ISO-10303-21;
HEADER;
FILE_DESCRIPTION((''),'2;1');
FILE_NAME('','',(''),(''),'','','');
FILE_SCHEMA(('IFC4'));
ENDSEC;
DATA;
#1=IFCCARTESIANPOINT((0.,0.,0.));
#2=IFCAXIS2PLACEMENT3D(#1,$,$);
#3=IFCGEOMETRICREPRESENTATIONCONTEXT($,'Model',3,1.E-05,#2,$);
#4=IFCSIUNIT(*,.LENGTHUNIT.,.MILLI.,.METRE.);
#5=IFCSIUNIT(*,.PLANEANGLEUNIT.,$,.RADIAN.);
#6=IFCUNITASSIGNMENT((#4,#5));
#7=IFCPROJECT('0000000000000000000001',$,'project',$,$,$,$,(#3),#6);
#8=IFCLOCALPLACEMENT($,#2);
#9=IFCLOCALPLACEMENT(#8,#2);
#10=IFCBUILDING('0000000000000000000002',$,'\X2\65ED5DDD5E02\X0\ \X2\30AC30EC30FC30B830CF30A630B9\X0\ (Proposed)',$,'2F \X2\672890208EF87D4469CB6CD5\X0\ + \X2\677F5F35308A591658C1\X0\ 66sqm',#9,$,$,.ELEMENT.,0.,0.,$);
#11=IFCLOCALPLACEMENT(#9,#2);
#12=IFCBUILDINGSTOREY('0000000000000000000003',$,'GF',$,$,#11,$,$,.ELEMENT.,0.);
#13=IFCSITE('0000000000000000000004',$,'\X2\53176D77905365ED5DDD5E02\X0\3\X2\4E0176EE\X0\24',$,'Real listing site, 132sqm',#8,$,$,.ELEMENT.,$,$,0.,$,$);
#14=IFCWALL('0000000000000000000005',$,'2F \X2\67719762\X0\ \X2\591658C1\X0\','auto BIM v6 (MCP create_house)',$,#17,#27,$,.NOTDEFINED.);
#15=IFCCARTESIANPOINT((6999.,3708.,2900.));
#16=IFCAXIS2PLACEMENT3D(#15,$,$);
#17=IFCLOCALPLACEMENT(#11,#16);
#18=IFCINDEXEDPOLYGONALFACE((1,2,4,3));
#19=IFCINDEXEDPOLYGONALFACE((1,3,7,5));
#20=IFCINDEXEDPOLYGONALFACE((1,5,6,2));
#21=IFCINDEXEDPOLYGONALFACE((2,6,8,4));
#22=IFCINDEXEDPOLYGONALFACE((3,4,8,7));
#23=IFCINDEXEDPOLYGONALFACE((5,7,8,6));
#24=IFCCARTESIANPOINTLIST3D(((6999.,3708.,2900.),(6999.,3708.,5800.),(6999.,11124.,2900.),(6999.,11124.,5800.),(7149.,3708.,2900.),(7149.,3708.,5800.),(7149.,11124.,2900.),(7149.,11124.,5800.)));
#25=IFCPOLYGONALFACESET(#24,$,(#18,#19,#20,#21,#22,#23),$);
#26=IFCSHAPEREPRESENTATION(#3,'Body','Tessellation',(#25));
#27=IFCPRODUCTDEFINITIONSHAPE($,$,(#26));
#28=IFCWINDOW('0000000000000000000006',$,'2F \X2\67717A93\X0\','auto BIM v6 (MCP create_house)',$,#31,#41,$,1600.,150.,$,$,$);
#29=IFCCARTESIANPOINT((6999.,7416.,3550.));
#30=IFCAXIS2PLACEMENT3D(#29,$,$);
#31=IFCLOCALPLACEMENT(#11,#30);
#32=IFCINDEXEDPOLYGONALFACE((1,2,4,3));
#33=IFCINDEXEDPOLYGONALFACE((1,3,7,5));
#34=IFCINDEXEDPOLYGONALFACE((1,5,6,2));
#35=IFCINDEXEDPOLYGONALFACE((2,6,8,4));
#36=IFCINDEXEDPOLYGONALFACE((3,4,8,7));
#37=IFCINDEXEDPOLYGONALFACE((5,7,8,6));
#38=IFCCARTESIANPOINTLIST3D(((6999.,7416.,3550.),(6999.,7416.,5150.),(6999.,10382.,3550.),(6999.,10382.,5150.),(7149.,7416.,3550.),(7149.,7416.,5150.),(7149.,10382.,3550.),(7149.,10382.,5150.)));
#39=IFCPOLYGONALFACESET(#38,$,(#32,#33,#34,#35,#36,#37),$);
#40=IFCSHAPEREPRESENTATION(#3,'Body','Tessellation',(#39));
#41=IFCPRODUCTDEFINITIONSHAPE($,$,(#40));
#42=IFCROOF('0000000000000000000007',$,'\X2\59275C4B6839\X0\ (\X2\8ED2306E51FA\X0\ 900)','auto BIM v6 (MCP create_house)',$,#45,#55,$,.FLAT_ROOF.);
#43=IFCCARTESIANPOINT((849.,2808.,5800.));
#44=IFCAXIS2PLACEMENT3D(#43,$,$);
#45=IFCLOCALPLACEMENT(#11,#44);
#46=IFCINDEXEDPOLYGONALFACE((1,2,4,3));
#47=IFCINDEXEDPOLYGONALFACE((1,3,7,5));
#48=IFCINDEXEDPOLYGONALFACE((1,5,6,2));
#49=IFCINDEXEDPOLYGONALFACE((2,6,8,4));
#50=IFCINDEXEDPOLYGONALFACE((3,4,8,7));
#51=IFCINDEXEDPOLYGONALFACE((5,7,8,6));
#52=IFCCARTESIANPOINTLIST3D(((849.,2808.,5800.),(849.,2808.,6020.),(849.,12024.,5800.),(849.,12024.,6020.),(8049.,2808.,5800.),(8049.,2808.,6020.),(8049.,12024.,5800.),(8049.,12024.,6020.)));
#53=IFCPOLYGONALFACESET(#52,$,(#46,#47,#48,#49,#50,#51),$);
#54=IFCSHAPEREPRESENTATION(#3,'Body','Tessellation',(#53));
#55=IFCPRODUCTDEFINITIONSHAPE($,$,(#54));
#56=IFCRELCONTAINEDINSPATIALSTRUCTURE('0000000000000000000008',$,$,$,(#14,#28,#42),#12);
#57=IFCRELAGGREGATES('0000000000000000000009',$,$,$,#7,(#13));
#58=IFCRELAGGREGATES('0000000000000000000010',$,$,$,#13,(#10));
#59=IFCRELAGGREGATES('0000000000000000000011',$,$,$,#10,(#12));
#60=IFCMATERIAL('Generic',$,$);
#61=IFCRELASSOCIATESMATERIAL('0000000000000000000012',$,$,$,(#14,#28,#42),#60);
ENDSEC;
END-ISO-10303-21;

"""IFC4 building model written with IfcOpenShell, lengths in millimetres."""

from ifc_helpers import new_model, si_unit, frame, frame_2d, origin, place, context, project, spatial, rectangle, extrude, material, element, fill, save


model = new_model("IFC4")

# Units and contexts
model_context = context("Model", 3, precision=1e-05, world=origin())
ifc_project = project(units=[si_unit("LENGTHUNIT", "METRE", prefix="MILLI"), si_unit("PLANEANGLEUNIT", "RADIAN")], contexts=[model_context])

# Site, building, storey
site_placement = place(None, origin())
site = spatial("IfcSite", under=ifc_project, at=site_placement, Name="北海道旭川市3丁目24", ObjectType="Real listing site, 132sqm", CompositionType="ELEMENT", RefElevation=0.0)
building_placement = place(site_placement, origin())
building = spatial("IfcBuilding", under=site, at=building_placement, Name="旭川市 ガレージハウス (Proposed)", ObjectType="2F 木造軸組構法 + 板張り外壁 66sqm", CompositionType="ELEMENT", ElevationOfRefHeight=0.0, ElevationOfTerrain=0.0)
storey_placement = place(building_placement, origin())
storey = spatial("IfcBuildingStorey", under=building, at=storey_placement, Name="GF", CompositionType="ELEMENT", Elevation=0.0)

# Shared definitions
ifc_material = material(Name="Generic")

# Wall, opening, window
wall_1_placement = place(storey_placement, frame((6999.0, 3708.0, 2900.0)))
wall_1 = element("IfcWall", 1, at=wall_1_placement, inside=storey, material=ifc_material, Name="2F 東面 外壁", Description="auto BIM v6 (MCP create_house)", PredefinedType="NOTDEFINED", context=model_context, shape_type="SweptSolid", body=[
    extrude(rectangle(XDim=150.0, YDim=7416.0, at=frame_2d((75.0, 3708.0))), frame((6999.0, 3708.0, 2900.0)), (0.0, 0.0, 1.0), 2900.0),
])
opening_1_placement = place(storey_placement, frame((6999.0, 7416.0, 3550.0)))
opening_1 = element("IfcOpeningElement", 2, at=opening_1_placement, cuts=wall_1, PredefinedType="NOTDEFINED", context=model_context, shape_type="SweptSolid", body=[
    extrude(rectangle(XDim=150.0, YDim=2966.0, at=frame_2d((75.0, 1483.0))), frame((6999.0, 7416.0, 3550.0)), (0.0, 0.0, 1.0), 1600.0),
])
window_1_placement = place(storey_placement, frame((6999.0, 7416.0, 3550.0)))
window_1 = element("IfcWindow", 3, at=window_1_placement, inside=storey, material=ifc_material, Name="2F 東窓", Description="auto BIM v6 (MCP create_house)", OverallHeight=1600.0, OverallWidth=150.0, context=model_context, shape_type="SweptSolid", body=[
    extrude(rectangle(XDim=150.0, YDim=2966.0, at=frame_2d((75.0, 1483.0))), frame((6999.0, 7416.0, 3550.0)), (0.0, 0.0, 1.0), 1600.0),
])
fill(opening_1, window_1)

# Roof
roof_placement = place(storey_placement, frame((849.0, 2808.0, 5800.0)))
element("IfcRoof", 4, at=roof_placement, inside=storey, material=ifc_material, Name="大屋根 (軒の出 900)", Description="auto BIM v6 (MCP create_house)", PredefinedType="FLAT_ROOF", context=model_context, shape_type="SweptSolid", body=[
    extrude(rectangle(XDim=7200.0, YDim=9216.0, at=frame_2d((3600.0, 4608.0))), frame((849.0, 2808.0, 5800.0)), (0.0, 0.0, 1.0), 220.0),
])

save(model, "model.ifc")
